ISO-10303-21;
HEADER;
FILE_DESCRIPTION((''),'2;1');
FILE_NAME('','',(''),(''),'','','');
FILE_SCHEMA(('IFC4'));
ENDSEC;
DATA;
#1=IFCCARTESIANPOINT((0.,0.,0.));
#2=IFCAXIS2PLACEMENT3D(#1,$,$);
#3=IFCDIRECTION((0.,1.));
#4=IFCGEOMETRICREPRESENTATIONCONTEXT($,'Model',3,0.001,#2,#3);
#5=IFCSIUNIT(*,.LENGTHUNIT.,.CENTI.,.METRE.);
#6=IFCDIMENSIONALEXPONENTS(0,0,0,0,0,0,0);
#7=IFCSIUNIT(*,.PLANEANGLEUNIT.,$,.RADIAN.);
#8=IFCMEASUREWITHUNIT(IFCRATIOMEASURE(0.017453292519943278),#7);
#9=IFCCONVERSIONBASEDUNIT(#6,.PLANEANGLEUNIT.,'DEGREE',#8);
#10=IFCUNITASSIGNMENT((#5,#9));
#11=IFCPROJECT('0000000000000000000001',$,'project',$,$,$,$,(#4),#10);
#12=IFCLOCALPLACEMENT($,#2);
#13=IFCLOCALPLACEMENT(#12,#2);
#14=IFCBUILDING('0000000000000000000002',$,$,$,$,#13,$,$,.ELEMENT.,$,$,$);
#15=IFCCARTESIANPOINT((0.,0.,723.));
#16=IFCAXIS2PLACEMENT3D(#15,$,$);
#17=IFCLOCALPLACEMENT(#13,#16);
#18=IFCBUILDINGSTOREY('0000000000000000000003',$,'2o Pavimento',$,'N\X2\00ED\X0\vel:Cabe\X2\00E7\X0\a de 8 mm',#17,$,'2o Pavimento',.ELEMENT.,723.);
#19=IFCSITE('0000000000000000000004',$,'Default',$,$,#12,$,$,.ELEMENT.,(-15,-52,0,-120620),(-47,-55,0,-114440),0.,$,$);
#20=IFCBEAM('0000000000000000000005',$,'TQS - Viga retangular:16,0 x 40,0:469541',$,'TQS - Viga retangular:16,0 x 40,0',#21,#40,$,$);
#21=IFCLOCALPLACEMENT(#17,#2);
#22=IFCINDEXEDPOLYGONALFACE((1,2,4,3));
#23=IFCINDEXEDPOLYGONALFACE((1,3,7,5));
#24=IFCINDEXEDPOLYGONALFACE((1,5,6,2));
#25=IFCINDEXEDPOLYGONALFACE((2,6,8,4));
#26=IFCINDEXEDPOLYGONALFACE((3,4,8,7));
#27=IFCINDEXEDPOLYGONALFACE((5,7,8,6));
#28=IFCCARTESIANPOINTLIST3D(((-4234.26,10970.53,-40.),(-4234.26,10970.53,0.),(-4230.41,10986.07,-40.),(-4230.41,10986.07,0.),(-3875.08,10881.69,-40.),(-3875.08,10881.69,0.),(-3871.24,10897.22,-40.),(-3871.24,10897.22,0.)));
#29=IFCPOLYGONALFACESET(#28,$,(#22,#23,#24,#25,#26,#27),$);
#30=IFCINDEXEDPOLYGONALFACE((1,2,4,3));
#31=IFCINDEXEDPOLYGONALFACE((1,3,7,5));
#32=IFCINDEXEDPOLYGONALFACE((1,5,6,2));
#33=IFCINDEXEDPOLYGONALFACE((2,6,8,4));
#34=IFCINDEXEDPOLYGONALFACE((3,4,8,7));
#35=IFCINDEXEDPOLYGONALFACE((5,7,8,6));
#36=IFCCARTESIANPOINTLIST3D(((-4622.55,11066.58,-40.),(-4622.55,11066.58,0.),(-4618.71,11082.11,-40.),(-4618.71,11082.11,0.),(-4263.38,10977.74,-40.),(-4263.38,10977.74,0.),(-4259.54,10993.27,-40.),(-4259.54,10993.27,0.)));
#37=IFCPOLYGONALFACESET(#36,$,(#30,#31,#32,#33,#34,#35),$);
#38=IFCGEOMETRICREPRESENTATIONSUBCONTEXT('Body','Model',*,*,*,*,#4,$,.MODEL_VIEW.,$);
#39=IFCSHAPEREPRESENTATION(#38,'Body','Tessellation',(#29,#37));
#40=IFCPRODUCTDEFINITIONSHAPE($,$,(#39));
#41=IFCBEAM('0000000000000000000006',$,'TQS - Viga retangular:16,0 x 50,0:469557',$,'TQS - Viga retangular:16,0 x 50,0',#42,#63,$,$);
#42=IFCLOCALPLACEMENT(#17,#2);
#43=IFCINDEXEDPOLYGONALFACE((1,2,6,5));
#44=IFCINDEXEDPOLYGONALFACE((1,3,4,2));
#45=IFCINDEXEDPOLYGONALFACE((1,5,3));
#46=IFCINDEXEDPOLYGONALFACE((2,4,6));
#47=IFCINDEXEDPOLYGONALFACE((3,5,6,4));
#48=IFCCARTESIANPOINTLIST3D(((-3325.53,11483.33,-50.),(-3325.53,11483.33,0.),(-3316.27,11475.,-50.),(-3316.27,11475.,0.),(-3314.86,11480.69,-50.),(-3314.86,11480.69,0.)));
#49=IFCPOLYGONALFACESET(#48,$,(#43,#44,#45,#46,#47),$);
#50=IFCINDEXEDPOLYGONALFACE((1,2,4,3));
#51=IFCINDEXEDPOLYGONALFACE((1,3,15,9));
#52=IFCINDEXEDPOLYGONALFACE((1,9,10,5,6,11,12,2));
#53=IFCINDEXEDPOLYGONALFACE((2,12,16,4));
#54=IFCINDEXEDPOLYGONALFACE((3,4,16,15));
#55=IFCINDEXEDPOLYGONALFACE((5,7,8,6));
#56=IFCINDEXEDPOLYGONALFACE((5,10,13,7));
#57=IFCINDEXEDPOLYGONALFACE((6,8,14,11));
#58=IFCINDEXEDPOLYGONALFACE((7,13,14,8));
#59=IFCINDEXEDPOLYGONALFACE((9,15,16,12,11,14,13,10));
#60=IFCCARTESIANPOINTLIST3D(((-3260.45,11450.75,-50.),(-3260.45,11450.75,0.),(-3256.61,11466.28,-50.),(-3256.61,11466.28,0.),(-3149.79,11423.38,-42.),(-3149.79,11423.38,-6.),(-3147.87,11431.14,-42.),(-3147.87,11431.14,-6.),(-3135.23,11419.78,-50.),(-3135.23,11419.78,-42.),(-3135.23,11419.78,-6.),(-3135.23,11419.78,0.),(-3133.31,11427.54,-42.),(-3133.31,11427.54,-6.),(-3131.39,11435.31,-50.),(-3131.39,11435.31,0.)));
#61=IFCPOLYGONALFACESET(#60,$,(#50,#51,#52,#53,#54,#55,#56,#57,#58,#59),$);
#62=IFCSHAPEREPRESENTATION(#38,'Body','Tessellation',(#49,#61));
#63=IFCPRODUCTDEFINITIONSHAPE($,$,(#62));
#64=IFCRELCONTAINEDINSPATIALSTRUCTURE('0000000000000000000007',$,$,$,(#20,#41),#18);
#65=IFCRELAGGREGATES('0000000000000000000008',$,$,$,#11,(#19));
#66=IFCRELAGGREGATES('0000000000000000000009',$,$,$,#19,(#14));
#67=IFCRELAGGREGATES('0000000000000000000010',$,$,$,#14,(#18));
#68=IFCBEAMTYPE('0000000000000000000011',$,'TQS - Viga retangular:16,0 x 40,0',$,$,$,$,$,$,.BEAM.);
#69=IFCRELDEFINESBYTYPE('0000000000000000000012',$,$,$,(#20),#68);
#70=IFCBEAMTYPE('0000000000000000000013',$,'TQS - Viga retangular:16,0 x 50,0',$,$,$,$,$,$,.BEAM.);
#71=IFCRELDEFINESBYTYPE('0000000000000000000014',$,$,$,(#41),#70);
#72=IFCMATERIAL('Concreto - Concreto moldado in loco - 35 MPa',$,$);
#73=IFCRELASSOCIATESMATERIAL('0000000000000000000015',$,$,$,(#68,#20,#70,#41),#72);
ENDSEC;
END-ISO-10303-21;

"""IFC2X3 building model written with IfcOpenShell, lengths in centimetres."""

from ifc_helpers import new_model, entity, si_unit, converted_unit, direction, frame, frame_2d, origin, origin_2d_with_axis, place, context, subcontext, project, spatial, polyline, rectangle, extrude, boolean, clip, halfspace, bounded_halfspace, source, transform, mapped, material, type_object, type_shapes, element, save


model = new_model("IFC2X3")

# Units and contexts
model_context = context("Model", 3, precision=0.001, world=origin(), true_north=direction((0.0, 1.0)))
body_context = subcontext(model_context, "Body", "Model", "MODEL_VIEW")
ifc_project = project(units=[si_unit("LENGTHUNIT", "METRE", prefix="CENTI"), converted_unit("PLANEANGLEUNIT", "DEGREE", entity("IfcRatioMeasure", 0.017453292519943278), si_unit("PLANEANGLEUNIT", "RADIAN"), dimensions=[0, 0, 0, 0, 0, 0, 0])], contexts=[model_context])

# Site, building, storey
site_placement = place(None, origin())
site = spatial("IfcSite", under=ifc_project, at=site_placement, Name="Default", CompositionType="ELEMENT", RefLatitude=(-15, -52, 0, -120620), RefLongitude=(-47, -55, 0, -114440), RefElevation=0.0)
building_placement = place(site_placement, origin())
building = spatial("IfcBuilding", under=site, at=building_placement, CompositionType="ELEMENT")
storey_placement = place(building_placement, frame((0.0, 0.0, 723.0)))
storey = spatial("IfcBuildingStorey", under=building, at=storey_placement, Name="2o Pavimento", ObjectType="Nível:Cabeça de 8 mm", LongName="2o Pavimento", CompositionType="ELEMENT", Elevation=723.0)

# Shared definitions
ifc_material = material(Name="Concreto - Concreto moldado in loco - 35 MPa")

# Beams
beam_type_1 = type_object("IfcBeamType", Name="TQS - Viga retangular:16,0 x 40,0", PredefinedType="BEAM", material=ifc_material)
shared_shape_1 = source(origin(), body_context, "Body", "SweptSolid", [
    extrude(rectangle(XDim=40.0, YDim=16.0, at=frame_2d((0.0, 0.0), x_axis=(1.0, 0.0))), frame((-3873.16, 10889.45, 703.0), z_axis=(-0.970743, 0.240122, 0.0), x_axis=(0.0, 0.0, 1.0)), (0.0, 0.0, 1.0), 370.0),
    extrude(rectangle(XDim=40.0, YDim=16.0, at=origin_2d_with_axis()), frame((-4261.46, 10985.5, 703.0), z_axis=(-0.970743, 0.240122, 0.0), x_axis=(0.0, 0.0, 1.0)), (0.0, 0.0, 1.0), 370.0),
])
type_shapes(beam_type_1, [shared_shape_1])
beam_1_placement = place(storey_placement, frame((0.0, 0.0, -723.0)))
element("IfcBeam", 1, at=beam_1_placement, inside=storey, type_object=beam_type_1, material=ifc_material, Name="TQS - Viga retangular:16,0 x 40,0:469541", ObjectType="TQS - Viga retangular:16,0 x 40,0", context=body_context, shape_type="MappedRepresentation", body=[
    mapped(shared_shape_1, transform((0.0, 0.0, 0.0), scale=1.0)),
])
beam_type_2 = type_object("IfcBeamType", Name="TQS - Viga retangular:16,0 x 50,0", PredefinedType="BEAM", material=ifc_material)
shared_shape_2 = source(origin(), body_context, "Body", "SweptSolid", [
    clip(extrude(rectangle(XDim=50.0, YDim=5.87, at=frame_2d((0.0, 0.0), x_axis=(1.0, 0.0))), frame((-3315.56, 11477.84, 698.0), z_axis=(-0.970743, 0.240122, 0.0), x_axis=(0.0, 0.0, 1.0)), (0.0, 0.0, 1.0), 11.0), halfspace(frame((-3300.25, 11460.6, 723.0), z_axis=(-0.668693, -0.743539, 0.0), x_axis=(0.743539, -0.668693, 0.0)), False)),
    boolean("DIFFERENCE", clip(extrude(rectangle(XDim=50.0, YDim=16.0, at=frame_2d((0.0, 0.0), x_axis=(0.0, 1.0))), frame((-3133.31, 11427.54, 698.0), z_axis=(-0.970743, 0.240122, 0.0), x_axis=(0.240122, 0.970743, 0.0)), (0.0, 0.0, 1.0), 129.0), bounded_halfspace(frame((-3147.87, 11431.14, 681.0), z_axis=(0.970743, -0.240122, 0.0), x_axis=(-0.240122, -0.970743, 0.0)), False, frame((-3133.31, 11427.54, 698.0), z_axis=(-0.970743, 0.240122, 0.0), x_axis=(0.240122, 0.970743, 0.0)), polyline([(0.0, 17.0), (0.0, -19.0), (-8.0, -19.0), (-8.0, -9.0), (-8.0, 17.0), (0.0, 17.0)]))), extrude(rectangle(XDim=36.0, YDim=8.0, at=frame_2d((0.0, 0.0), x_axis=(0.0, 1.0))), frame((-3134.27, 11423.66, 699.0), z_axis=(0.970743, -0.240122, 0.0), x_axis=(0.240122, 0.970743, 0.0)), (0.0, 0.0, -1.0), 15.0)),
])
type_shapes(beam_type_2, [shared_shape_2])
beam_2_placement = place(storey_placement, frame((0.0, 0.0, -723.0)))
element("IfcBeam", 2, at=beam_2_placement, inside=storey, type_object=beam_type_2, material=ifc_material, Name="TQS - Viga retangular:16,0 x 50,0:469557", ObjectType="TQS - Viga retangular:16,0 x 50,0", context=body_context, shape_type="MappedRepresentation", body=[
    mapped(shared_shape_2, transform((0.0, 0.0, 0.0), scale=1.0)),
])

save(model, "model.ifc")
